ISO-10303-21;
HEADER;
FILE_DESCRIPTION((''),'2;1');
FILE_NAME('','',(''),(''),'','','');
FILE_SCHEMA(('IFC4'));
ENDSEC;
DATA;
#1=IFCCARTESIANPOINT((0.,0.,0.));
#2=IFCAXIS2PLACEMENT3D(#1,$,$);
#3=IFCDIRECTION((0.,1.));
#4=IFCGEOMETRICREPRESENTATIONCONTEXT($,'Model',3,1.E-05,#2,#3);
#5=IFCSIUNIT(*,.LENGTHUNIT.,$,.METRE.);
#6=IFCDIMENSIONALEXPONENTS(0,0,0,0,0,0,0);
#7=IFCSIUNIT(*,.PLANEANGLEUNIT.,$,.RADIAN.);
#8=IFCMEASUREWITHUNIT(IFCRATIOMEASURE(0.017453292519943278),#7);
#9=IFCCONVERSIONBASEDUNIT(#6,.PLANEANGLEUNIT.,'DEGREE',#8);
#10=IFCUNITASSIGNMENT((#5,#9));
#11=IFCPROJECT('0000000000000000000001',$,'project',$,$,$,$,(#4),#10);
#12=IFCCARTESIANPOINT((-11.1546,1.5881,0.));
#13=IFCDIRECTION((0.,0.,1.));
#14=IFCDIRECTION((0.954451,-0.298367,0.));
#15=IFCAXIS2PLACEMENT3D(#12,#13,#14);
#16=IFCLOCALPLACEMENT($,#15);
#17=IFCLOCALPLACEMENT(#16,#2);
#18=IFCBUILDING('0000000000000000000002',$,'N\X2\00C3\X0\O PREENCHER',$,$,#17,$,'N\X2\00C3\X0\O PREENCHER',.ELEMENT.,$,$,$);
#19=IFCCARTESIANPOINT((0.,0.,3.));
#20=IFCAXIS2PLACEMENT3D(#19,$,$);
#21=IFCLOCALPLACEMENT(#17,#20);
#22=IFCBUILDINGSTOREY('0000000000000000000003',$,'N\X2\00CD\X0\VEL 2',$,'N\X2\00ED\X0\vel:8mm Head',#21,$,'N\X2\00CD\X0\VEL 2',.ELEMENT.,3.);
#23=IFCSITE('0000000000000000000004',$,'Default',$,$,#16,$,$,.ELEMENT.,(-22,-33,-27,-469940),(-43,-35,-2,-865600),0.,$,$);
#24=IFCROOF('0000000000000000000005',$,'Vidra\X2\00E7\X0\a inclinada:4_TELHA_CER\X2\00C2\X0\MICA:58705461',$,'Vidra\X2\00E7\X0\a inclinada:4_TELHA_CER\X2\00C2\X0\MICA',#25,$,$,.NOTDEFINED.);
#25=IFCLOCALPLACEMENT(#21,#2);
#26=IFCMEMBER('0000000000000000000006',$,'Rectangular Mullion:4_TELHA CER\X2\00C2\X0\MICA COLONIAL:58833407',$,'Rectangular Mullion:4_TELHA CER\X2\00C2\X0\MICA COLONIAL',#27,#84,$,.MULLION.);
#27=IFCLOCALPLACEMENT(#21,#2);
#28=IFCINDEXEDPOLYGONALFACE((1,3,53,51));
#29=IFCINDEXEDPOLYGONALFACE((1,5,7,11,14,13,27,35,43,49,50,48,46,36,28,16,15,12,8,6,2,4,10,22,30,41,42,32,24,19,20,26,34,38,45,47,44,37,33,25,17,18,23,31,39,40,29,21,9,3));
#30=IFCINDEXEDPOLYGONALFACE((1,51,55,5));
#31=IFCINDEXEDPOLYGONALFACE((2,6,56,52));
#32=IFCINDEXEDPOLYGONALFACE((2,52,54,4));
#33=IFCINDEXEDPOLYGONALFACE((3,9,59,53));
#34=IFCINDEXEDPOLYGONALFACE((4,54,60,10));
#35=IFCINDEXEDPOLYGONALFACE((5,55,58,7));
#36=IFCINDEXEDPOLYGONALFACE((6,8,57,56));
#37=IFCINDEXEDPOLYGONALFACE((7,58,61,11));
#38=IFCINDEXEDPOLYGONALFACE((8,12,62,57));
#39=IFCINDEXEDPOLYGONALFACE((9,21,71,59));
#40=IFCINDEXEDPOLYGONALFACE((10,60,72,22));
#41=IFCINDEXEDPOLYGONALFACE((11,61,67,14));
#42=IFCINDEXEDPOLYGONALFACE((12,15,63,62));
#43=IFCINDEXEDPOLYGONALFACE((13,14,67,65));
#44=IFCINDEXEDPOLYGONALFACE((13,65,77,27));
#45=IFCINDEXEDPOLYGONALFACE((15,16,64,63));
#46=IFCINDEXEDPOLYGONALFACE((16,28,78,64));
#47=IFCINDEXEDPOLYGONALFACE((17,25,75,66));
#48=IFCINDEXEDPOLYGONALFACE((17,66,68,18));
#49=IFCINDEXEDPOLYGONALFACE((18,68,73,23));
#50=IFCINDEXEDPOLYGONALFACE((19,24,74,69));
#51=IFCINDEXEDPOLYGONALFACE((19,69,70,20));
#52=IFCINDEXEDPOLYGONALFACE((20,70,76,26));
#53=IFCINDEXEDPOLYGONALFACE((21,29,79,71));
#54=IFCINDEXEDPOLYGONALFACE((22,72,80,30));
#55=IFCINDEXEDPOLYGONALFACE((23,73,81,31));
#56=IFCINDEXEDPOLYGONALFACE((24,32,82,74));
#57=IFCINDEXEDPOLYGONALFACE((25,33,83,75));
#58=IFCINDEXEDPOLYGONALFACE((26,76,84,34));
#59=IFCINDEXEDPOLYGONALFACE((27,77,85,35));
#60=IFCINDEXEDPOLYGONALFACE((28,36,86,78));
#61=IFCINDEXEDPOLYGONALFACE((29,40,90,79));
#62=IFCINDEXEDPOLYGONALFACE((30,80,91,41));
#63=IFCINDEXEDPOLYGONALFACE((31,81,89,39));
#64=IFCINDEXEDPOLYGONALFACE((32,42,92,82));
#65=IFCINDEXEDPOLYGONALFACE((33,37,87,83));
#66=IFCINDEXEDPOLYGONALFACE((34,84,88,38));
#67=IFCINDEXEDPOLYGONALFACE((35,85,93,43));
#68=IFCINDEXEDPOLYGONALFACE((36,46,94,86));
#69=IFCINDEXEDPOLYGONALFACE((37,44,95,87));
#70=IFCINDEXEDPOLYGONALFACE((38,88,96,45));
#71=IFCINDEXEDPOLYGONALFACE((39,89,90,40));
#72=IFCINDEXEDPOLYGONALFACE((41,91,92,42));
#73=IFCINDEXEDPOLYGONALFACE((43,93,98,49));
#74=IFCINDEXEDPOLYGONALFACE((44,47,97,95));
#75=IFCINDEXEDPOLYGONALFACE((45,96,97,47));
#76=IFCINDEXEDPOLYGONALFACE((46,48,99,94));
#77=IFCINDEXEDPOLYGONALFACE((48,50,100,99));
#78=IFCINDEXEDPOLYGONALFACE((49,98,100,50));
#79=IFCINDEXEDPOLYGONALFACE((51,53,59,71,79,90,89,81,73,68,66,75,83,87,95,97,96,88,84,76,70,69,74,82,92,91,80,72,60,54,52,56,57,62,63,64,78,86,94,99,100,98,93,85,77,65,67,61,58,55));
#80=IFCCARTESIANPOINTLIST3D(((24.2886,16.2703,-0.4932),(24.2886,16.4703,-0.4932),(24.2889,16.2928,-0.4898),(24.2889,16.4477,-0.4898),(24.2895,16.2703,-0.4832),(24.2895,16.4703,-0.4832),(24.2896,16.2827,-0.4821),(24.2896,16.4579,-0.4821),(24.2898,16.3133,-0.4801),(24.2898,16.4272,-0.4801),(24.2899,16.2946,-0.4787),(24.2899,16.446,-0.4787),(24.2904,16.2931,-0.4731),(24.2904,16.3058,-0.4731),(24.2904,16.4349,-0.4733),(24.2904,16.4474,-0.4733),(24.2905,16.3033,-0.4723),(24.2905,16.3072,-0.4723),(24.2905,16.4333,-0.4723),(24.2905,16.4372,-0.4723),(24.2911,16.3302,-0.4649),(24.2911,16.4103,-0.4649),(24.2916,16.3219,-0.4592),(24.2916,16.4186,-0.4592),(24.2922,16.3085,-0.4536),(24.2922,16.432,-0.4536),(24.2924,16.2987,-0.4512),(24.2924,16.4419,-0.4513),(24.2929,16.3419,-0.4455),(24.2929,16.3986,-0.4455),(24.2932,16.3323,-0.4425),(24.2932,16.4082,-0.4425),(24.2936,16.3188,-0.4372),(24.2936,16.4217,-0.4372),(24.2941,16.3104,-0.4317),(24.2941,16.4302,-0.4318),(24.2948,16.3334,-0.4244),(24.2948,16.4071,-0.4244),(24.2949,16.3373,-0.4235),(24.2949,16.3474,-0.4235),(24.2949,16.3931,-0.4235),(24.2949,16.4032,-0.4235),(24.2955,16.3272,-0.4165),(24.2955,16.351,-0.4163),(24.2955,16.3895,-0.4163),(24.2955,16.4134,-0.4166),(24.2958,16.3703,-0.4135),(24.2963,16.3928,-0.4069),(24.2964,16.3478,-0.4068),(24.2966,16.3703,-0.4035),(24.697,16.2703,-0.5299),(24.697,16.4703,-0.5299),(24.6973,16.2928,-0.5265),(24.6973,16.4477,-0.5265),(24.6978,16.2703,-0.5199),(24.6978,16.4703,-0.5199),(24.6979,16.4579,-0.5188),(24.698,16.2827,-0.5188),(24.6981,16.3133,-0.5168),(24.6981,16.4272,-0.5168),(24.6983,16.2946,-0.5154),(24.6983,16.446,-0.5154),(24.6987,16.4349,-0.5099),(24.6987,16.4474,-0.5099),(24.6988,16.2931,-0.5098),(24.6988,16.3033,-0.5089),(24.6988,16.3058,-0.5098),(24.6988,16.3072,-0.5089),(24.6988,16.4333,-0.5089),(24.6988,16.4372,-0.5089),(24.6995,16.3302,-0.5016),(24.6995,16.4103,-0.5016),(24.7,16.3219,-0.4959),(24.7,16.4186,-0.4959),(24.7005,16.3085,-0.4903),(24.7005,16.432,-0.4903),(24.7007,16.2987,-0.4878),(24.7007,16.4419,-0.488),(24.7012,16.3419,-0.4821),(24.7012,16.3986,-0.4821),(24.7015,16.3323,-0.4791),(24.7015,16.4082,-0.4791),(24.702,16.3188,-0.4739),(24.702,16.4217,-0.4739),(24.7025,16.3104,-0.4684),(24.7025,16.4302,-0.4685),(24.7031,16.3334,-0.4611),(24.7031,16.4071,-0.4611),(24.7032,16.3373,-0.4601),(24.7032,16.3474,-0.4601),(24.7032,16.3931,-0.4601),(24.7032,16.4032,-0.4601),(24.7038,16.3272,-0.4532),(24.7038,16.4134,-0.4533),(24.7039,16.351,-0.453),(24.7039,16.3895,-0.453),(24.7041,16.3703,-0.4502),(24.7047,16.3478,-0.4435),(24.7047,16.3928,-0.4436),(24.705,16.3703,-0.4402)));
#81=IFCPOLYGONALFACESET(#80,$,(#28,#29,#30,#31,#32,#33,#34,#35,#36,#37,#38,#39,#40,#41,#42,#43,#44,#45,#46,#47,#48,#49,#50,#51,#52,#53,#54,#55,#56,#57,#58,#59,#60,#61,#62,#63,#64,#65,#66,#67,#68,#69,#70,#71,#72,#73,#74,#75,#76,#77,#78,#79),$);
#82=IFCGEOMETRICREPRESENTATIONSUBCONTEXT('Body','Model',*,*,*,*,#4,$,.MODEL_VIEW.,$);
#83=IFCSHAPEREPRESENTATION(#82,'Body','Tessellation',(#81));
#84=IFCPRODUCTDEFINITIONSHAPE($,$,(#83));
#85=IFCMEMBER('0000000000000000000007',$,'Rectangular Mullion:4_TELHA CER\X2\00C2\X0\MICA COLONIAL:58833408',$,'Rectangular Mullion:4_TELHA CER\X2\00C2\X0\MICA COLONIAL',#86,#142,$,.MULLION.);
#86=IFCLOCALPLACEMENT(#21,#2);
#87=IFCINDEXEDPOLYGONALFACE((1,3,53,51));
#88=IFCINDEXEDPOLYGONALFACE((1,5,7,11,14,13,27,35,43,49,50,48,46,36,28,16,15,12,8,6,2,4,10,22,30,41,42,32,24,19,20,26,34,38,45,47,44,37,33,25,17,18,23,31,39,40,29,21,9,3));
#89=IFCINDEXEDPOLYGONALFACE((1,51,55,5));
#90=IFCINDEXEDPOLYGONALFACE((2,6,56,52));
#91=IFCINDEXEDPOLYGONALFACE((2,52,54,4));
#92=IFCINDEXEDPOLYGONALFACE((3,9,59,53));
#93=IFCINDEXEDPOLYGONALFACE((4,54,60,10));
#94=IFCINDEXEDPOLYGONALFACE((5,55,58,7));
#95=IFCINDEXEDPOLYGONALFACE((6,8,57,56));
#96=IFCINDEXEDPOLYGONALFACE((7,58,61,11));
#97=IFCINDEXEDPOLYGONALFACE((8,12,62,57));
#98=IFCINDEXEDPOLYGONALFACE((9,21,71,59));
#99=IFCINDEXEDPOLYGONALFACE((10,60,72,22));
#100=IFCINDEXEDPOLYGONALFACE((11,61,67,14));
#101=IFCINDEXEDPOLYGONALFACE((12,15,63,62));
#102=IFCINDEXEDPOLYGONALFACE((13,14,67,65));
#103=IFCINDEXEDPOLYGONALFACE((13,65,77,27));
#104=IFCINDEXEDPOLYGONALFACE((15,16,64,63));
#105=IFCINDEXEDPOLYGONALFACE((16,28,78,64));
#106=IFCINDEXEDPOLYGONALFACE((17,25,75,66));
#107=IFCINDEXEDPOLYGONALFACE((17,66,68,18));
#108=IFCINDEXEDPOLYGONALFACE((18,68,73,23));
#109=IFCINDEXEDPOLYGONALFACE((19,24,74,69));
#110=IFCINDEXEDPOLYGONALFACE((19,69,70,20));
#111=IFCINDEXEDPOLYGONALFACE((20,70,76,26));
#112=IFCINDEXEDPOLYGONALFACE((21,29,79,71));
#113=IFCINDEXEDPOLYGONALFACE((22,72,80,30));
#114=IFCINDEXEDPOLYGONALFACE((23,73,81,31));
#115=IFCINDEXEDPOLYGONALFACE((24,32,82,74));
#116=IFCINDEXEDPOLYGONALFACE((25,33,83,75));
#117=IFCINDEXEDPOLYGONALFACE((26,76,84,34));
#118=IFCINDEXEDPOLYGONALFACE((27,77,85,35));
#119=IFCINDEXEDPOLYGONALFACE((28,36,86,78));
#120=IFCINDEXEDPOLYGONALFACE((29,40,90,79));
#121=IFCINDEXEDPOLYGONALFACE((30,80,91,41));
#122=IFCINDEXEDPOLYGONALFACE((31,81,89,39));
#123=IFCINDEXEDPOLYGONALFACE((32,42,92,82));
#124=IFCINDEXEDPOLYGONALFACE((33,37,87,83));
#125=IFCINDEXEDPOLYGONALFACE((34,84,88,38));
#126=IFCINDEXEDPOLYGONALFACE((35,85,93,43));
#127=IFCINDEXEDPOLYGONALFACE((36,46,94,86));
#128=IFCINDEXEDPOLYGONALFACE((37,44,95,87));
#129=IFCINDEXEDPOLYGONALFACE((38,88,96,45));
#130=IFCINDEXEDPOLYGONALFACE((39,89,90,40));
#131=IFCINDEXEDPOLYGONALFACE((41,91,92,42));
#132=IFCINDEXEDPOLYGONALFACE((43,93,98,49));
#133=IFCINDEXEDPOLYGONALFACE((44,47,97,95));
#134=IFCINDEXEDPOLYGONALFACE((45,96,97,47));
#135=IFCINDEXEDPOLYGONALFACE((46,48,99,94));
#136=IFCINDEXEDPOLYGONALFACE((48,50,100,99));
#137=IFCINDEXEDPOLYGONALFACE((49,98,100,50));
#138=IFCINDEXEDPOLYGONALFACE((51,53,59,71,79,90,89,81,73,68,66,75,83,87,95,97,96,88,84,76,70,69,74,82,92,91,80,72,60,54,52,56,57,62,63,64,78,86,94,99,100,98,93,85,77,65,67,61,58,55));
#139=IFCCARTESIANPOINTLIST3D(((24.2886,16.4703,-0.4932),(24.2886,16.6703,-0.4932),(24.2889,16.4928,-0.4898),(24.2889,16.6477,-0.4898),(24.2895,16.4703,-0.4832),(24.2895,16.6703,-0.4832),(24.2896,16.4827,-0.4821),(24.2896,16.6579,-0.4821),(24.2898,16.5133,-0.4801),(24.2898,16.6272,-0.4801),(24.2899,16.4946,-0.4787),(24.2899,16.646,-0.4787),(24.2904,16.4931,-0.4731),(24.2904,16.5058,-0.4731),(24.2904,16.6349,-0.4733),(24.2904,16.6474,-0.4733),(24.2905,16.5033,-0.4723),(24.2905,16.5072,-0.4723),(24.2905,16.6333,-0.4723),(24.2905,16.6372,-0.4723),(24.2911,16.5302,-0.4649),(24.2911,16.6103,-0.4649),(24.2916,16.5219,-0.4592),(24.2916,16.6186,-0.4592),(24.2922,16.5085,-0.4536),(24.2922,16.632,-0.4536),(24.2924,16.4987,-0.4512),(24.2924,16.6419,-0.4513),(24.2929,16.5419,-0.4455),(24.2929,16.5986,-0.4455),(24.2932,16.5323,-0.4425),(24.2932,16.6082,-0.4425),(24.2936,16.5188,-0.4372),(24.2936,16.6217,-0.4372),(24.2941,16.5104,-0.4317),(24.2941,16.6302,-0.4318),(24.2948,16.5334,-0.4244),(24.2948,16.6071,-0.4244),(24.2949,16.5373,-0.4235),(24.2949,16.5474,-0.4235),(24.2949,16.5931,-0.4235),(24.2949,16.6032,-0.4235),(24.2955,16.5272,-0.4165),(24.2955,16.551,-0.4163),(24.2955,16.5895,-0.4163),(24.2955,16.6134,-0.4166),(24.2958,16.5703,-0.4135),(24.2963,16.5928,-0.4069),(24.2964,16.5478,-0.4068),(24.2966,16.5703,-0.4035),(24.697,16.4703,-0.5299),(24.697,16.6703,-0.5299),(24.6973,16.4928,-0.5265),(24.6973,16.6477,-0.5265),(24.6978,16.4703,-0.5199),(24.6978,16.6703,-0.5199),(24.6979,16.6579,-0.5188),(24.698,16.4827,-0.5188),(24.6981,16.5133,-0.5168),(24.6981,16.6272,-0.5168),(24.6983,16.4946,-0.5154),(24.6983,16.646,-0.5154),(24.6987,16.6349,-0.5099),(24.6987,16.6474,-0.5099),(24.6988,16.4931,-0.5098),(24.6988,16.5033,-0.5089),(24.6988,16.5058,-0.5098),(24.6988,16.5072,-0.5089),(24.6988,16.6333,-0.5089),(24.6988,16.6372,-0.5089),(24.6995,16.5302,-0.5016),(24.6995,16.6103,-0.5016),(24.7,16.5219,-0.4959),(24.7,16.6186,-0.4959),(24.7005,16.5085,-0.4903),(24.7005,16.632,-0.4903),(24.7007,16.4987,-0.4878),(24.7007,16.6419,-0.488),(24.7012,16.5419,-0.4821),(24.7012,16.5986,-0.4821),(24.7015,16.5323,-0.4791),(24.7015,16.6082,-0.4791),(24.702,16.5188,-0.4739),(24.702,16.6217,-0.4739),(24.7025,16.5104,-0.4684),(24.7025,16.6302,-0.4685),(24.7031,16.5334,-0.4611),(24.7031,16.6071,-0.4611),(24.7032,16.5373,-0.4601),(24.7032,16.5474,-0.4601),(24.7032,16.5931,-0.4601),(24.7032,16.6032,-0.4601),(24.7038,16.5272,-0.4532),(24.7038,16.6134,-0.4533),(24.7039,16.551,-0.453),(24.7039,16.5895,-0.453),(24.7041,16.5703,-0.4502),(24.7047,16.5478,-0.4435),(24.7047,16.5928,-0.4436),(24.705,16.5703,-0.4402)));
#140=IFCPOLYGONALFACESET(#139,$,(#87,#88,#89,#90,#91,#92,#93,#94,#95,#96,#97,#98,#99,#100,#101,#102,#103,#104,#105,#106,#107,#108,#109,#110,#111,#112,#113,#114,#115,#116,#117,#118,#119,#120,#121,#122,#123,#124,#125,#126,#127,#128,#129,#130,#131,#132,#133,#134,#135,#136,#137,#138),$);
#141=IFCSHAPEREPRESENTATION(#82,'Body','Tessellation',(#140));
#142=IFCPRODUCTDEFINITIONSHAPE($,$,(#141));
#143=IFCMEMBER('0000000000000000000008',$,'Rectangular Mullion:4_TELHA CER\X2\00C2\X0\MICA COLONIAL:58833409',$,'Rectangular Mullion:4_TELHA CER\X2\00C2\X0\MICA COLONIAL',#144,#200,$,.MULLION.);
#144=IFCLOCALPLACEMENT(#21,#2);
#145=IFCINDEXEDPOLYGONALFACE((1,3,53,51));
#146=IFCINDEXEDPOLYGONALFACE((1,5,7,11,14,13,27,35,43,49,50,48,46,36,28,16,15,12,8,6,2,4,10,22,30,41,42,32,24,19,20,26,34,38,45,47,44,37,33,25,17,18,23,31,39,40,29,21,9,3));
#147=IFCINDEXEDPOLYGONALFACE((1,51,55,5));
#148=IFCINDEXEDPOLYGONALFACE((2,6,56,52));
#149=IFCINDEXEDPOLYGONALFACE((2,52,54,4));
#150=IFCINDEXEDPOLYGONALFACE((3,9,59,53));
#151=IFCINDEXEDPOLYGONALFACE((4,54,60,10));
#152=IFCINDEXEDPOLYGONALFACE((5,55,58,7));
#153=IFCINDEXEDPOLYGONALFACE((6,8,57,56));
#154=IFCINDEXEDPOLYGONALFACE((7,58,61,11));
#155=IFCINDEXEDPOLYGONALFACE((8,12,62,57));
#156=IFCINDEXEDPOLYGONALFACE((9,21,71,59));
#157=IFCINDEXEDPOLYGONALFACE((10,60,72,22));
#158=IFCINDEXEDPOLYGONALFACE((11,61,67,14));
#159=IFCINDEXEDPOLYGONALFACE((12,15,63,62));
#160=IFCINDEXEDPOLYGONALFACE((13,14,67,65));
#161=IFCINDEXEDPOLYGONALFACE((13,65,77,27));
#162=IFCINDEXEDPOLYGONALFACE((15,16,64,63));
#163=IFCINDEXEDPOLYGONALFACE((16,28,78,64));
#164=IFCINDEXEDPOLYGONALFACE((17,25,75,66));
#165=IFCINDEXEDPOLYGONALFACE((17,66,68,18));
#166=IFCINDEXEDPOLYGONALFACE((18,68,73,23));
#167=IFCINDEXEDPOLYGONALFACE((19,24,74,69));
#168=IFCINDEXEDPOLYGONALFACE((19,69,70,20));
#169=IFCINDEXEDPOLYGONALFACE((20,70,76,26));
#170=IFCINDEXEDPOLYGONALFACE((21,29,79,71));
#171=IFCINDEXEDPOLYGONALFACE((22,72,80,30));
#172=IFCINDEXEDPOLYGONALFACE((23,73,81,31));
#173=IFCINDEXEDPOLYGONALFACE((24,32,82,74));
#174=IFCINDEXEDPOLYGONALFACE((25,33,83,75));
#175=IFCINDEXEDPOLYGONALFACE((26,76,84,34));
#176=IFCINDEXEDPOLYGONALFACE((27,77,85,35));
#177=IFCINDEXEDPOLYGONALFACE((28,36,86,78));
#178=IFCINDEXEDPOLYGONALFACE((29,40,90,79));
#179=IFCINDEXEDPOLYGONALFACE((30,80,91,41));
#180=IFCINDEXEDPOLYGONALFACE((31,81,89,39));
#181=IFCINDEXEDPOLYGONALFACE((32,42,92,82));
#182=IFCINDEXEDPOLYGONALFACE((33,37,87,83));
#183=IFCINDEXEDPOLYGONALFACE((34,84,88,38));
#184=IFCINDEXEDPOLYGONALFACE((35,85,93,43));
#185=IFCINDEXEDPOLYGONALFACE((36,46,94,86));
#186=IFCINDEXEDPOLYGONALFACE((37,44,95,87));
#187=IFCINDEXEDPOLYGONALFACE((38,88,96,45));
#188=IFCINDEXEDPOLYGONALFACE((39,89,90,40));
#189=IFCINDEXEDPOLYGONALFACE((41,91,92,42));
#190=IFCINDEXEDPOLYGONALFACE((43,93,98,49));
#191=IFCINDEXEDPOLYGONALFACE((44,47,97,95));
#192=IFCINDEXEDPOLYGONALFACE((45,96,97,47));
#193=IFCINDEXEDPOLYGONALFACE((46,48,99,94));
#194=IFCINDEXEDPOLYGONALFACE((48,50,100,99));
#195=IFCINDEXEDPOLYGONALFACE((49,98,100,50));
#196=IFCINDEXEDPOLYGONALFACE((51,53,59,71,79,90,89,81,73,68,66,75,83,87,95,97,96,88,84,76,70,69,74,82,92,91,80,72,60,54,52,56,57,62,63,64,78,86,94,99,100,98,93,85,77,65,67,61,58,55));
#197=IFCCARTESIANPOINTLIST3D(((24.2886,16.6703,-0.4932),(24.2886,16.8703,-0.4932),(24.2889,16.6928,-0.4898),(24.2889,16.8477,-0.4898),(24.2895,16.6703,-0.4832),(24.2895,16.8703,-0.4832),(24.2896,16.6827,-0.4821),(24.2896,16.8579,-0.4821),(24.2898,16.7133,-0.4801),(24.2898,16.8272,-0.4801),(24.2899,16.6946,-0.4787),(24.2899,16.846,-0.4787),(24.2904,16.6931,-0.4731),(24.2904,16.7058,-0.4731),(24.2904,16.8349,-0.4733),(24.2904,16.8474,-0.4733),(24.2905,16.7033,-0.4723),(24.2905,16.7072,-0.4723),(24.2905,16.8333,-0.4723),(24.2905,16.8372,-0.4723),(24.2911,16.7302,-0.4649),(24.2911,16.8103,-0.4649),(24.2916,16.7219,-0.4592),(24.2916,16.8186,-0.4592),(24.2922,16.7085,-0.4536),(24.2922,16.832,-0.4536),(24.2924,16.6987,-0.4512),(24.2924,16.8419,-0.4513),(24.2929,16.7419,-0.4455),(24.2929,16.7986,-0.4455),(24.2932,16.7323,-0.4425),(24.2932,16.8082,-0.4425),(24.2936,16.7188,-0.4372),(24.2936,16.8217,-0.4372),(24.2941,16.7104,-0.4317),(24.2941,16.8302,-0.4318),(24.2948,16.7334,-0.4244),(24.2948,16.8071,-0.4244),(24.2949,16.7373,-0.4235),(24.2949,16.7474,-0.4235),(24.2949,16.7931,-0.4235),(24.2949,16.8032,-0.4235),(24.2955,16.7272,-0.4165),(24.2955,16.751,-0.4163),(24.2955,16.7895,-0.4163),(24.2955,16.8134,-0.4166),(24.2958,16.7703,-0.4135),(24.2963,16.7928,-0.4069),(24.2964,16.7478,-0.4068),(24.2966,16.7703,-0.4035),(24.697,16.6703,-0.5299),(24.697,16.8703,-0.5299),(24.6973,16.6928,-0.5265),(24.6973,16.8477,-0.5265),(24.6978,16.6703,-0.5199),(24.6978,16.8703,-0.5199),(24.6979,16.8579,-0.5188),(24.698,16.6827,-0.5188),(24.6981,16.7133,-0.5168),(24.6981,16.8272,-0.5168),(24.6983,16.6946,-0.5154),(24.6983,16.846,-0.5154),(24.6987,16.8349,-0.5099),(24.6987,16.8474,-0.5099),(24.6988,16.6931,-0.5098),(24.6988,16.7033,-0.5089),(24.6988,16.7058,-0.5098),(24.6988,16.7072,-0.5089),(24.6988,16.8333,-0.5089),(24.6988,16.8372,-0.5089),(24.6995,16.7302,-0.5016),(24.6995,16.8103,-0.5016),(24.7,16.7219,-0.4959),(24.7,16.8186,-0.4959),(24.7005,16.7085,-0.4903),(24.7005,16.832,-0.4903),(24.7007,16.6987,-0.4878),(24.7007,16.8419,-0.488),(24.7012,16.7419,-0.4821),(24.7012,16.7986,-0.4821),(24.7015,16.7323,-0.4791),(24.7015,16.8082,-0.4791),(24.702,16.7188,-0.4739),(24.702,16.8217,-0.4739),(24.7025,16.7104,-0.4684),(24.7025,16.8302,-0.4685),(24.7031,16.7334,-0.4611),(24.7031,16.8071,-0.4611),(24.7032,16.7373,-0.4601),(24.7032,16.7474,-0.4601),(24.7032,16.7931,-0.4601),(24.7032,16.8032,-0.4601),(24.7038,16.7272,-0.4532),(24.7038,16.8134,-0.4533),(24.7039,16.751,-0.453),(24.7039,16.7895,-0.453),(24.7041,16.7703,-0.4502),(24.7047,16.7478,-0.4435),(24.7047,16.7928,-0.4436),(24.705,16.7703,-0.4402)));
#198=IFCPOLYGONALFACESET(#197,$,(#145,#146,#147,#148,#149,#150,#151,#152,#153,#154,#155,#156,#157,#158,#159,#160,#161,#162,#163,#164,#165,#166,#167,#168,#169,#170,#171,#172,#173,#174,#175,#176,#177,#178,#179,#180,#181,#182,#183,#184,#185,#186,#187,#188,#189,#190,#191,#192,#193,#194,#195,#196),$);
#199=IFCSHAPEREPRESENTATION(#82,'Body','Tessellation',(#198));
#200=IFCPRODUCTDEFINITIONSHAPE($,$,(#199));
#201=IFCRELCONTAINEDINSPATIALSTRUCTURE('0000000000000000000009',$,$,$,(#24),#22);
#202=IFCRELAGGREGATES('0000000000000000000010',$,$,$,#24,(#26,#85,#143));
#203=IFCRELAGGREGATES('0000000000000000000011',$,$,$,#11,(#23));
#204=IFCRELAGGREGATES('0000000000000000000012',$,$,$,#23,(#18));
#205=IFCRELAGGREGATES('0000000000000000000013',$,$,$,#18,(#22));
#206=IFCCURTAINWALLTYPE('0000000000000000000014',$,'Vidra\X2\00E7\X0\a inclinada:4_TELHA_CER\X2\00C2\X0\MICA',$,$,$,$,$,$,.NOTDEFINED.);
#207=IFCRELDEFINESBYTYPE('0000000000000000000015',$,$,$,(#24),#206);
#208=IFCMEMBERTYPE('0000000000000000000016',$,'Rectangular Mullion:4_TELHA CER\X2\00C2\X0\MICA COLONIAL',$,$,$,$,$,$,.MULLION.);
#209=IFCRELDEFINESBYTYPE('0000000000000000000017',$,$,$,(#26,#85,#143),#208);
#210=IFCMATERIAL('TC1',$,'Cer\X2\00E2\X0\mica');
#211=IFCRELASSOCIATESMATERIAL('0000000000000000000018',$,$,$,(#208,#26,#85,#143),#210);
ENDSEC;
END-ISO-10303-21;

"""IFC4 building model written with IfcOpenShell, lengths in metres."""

from ifc_helpers import new_model, entity, si_unit, converted_unit, direction, frame, origin, place, context, subcontext, project, spatial, line, arc, indexed_curve, outline, extrude, source, transform, mapped, material, type_object, type_shapes, element, aggregate, save


model = new_model("IFC4")

# Units and contexts
model_context = context("Model", 3, precision=1e-05, world=origin(), true_north=direction((0.0, 1.0)))
body_context = subcontext(model_context, "Body", "Model", "MODEL_VIEW")
ifc_project = project(units=[si_unit("LENGTHUNIT", "METRE"), converted_unit("PLANEANGLEUNIT", "DEGREE", entity("IfcRatioMeasure", 0.017453292519943278), si_unit("PLANEANGLEUNIT", "RADIAN"), dimensions=[0, 0, 0, 0, 0, 0, 0])], contexts=[model_context])

# Site, building, storey
site_placement = place(None, frame((-11.1546, 1.5881, 0.0), z_axis=(0.0, 0.0, 1.0), x_axis=(0.954451, -0.298367, 0.0)))
site = spatial("IfcSite", under=ifc_project, at=site_placement, Name="Default", CompositionType="ELEMENT", RefLatitude=(-22, -33, -27, -469940), RefLongitude=(-43, -35, -2, -865600), RefElevation=0.0)
building_placement = place(site_placement, origin())
building = spatial("IfcBuilding", under=site, at=building_placement, Name="NÃO PREENCHER", LongName="NÃO PREENCHER", CompositionType="ELEMENT")
storey_placement = place(building_placement, frame((0.0, 0.0, 3.0)))
storey = spatial("IfcBuildingStorey", under=building, at=storey_placement, Name="NÍVEL 2", ObjectType="Nível:8mm Head", LongName="NÍVEL 2", CompositionType="ELEMENT", Elevation=3.0)

# Roof, members
curtain_wall_type = type_object("IfcCurtainWallType", Name="Vidraça inclinada:4_TELHA_CERÂMICA", PredefinedType="NOTDEFINED")
roof_placement = place(storey_placement, frame((0.0, 0.0, -3.0)))
roof = element("IfcRoof", 1, at=roof_placement, inside=storey, type_object=curtain_wall_type, Name="Vidraça inclinada:4_TELHA_CERÂMICA:58705461", ObjectType="Vidraça inclinada:4_TELHA_CERÂMICA", PredefinedType="NOTDEFINED")
ifc_material_1 = material(Name="TC1", Category="Cerâmica")
member_type_1 = type_object("IfcMemberType", Name="Rectangular Mullion:4_TELHA CERÂMICA COLONIAL", PredefinedType="MULLION", material=ifc_material_1)
shared_shape_1 = source(origin(), body_context, "Body", "SweptSolid", [
    extrude(outline(indexed_curve([(-0.029, -0.1), (-0.019, -0.1), (-0.0164, -0.0815), (-0.0089, -0.0645), (-0.0089, -0.0771), (0.061, 0.0), (-0.009, 0.0771), (-0.009, 0.0646), (-0.0165, 0.0816), (-0.019, 0.1), (-0.029, 0.1), (-0.0089, 0.0479), (0.041, 0.0229), (0.041, 0.0329), (0.0131, 0.0425), (-0.008, 0.0631), (-0.008, 0.067), (0.051, 0.0), (-0.008, -0.067), (-0.008, -0.0631), (0.0131, -0.0425), (0.041, -0.0329), (0.041, -0.0229), (-0.0089, -0.0479)], segments=[line(1, 2), arc(2, 3, 4), line(4, 5), arc(5, 6, 7), line(7, 8), arc(8, 9, 10), line(10, 11), arc(11, 12, 13), line(13, 14), arc(14, 15, 16), line(16, 17), arc(17, 18, 19), line(19, 20), arc(20, 21, 22), line(22, 23), arc(23, 24, 1)], self_intersect=False)), frame((0.0, -0.029, -0.41), z_axis=(0.0, 0.0, 1.0), x_axis=(0.0, -1.0, 0.0)), (0.0, 0.0, 1.0), 0.41),
])
type_shapes(member_type_1, [shared_shape_1])
member_1_placement = place(roof_placement, frame((24.2886, 16.3703, 2.5068), z_axis=(-0.99599, 0.0, 0.089469), x_axis=(0.0, 1.0, 0.0)))
member_1 = element("IfcMember", 2, at=member_1_placement, type_object=member_type_1, material=ifc_material_1, Name="Rectangular Mullion:4_TELHA CERÂMICA COLONIAL:58833407", ObjectType="Rectangular Mullion:4_TELHA CERÂMICA COLONIAL", PredefinedType="MULLION", context=body_context, shape_type="MappedRepresentation", body=[
    mapped(shared_shape_1, transform((0.0, 0.0, 0.0), scale=1.0)),
])
member_2_placement = place(roof_placement, frame((24.2886, 16.5703, 2.5068), z_axis=(-0.99599, 0.0, 0.089469), x_axis=(0.0, 1.0, 0.0)))
member_2 = element("IfcMember", 3, at=member_2_placement, type_object=member_type_1, material=ifc_material_1, Name="Rectangular Mullion:4_TELHA CERÂMICA COLONIAL:58833408", ObjectType="Rectangular Mullion:4_TELHA CERÂMICA COLONIAL", PredefinedType="MULLION", context=body_context, shape_type="MappedRepresentation", body=[
    mapped(shared_shape_1, transform((0.0, 0.0, 0.0), scale=1.0)),
])
member_3_placement = place(roof_placement, frame((24.2886, 16.7703, 2.5068), z_axis=(-0.99599, 0.0, 0.089469), x_axis=(0.0, 1.0, 0.0)))
member_3 = element("IfcMember", 4, at=member_3_placement, type_object=member_type_1, material=ifc_material_1, Name="Rectangular Mullion:4_TELHA CERÂMICA COLONIAL:58833409", ObjectType="Rectangular Mullion:4_TELHA CERÂMICA COLONIAL", PredefinedType="MULLION", context=body_context, shape_type="MappedRepresentation", body=[
    mapped(shared_shape_1, transform((0.0, 0.0, 0.0), scale=1.0)),
])
aggregate(roof, [member_1, member_2, member_3])

save(model, "model.ifc")
